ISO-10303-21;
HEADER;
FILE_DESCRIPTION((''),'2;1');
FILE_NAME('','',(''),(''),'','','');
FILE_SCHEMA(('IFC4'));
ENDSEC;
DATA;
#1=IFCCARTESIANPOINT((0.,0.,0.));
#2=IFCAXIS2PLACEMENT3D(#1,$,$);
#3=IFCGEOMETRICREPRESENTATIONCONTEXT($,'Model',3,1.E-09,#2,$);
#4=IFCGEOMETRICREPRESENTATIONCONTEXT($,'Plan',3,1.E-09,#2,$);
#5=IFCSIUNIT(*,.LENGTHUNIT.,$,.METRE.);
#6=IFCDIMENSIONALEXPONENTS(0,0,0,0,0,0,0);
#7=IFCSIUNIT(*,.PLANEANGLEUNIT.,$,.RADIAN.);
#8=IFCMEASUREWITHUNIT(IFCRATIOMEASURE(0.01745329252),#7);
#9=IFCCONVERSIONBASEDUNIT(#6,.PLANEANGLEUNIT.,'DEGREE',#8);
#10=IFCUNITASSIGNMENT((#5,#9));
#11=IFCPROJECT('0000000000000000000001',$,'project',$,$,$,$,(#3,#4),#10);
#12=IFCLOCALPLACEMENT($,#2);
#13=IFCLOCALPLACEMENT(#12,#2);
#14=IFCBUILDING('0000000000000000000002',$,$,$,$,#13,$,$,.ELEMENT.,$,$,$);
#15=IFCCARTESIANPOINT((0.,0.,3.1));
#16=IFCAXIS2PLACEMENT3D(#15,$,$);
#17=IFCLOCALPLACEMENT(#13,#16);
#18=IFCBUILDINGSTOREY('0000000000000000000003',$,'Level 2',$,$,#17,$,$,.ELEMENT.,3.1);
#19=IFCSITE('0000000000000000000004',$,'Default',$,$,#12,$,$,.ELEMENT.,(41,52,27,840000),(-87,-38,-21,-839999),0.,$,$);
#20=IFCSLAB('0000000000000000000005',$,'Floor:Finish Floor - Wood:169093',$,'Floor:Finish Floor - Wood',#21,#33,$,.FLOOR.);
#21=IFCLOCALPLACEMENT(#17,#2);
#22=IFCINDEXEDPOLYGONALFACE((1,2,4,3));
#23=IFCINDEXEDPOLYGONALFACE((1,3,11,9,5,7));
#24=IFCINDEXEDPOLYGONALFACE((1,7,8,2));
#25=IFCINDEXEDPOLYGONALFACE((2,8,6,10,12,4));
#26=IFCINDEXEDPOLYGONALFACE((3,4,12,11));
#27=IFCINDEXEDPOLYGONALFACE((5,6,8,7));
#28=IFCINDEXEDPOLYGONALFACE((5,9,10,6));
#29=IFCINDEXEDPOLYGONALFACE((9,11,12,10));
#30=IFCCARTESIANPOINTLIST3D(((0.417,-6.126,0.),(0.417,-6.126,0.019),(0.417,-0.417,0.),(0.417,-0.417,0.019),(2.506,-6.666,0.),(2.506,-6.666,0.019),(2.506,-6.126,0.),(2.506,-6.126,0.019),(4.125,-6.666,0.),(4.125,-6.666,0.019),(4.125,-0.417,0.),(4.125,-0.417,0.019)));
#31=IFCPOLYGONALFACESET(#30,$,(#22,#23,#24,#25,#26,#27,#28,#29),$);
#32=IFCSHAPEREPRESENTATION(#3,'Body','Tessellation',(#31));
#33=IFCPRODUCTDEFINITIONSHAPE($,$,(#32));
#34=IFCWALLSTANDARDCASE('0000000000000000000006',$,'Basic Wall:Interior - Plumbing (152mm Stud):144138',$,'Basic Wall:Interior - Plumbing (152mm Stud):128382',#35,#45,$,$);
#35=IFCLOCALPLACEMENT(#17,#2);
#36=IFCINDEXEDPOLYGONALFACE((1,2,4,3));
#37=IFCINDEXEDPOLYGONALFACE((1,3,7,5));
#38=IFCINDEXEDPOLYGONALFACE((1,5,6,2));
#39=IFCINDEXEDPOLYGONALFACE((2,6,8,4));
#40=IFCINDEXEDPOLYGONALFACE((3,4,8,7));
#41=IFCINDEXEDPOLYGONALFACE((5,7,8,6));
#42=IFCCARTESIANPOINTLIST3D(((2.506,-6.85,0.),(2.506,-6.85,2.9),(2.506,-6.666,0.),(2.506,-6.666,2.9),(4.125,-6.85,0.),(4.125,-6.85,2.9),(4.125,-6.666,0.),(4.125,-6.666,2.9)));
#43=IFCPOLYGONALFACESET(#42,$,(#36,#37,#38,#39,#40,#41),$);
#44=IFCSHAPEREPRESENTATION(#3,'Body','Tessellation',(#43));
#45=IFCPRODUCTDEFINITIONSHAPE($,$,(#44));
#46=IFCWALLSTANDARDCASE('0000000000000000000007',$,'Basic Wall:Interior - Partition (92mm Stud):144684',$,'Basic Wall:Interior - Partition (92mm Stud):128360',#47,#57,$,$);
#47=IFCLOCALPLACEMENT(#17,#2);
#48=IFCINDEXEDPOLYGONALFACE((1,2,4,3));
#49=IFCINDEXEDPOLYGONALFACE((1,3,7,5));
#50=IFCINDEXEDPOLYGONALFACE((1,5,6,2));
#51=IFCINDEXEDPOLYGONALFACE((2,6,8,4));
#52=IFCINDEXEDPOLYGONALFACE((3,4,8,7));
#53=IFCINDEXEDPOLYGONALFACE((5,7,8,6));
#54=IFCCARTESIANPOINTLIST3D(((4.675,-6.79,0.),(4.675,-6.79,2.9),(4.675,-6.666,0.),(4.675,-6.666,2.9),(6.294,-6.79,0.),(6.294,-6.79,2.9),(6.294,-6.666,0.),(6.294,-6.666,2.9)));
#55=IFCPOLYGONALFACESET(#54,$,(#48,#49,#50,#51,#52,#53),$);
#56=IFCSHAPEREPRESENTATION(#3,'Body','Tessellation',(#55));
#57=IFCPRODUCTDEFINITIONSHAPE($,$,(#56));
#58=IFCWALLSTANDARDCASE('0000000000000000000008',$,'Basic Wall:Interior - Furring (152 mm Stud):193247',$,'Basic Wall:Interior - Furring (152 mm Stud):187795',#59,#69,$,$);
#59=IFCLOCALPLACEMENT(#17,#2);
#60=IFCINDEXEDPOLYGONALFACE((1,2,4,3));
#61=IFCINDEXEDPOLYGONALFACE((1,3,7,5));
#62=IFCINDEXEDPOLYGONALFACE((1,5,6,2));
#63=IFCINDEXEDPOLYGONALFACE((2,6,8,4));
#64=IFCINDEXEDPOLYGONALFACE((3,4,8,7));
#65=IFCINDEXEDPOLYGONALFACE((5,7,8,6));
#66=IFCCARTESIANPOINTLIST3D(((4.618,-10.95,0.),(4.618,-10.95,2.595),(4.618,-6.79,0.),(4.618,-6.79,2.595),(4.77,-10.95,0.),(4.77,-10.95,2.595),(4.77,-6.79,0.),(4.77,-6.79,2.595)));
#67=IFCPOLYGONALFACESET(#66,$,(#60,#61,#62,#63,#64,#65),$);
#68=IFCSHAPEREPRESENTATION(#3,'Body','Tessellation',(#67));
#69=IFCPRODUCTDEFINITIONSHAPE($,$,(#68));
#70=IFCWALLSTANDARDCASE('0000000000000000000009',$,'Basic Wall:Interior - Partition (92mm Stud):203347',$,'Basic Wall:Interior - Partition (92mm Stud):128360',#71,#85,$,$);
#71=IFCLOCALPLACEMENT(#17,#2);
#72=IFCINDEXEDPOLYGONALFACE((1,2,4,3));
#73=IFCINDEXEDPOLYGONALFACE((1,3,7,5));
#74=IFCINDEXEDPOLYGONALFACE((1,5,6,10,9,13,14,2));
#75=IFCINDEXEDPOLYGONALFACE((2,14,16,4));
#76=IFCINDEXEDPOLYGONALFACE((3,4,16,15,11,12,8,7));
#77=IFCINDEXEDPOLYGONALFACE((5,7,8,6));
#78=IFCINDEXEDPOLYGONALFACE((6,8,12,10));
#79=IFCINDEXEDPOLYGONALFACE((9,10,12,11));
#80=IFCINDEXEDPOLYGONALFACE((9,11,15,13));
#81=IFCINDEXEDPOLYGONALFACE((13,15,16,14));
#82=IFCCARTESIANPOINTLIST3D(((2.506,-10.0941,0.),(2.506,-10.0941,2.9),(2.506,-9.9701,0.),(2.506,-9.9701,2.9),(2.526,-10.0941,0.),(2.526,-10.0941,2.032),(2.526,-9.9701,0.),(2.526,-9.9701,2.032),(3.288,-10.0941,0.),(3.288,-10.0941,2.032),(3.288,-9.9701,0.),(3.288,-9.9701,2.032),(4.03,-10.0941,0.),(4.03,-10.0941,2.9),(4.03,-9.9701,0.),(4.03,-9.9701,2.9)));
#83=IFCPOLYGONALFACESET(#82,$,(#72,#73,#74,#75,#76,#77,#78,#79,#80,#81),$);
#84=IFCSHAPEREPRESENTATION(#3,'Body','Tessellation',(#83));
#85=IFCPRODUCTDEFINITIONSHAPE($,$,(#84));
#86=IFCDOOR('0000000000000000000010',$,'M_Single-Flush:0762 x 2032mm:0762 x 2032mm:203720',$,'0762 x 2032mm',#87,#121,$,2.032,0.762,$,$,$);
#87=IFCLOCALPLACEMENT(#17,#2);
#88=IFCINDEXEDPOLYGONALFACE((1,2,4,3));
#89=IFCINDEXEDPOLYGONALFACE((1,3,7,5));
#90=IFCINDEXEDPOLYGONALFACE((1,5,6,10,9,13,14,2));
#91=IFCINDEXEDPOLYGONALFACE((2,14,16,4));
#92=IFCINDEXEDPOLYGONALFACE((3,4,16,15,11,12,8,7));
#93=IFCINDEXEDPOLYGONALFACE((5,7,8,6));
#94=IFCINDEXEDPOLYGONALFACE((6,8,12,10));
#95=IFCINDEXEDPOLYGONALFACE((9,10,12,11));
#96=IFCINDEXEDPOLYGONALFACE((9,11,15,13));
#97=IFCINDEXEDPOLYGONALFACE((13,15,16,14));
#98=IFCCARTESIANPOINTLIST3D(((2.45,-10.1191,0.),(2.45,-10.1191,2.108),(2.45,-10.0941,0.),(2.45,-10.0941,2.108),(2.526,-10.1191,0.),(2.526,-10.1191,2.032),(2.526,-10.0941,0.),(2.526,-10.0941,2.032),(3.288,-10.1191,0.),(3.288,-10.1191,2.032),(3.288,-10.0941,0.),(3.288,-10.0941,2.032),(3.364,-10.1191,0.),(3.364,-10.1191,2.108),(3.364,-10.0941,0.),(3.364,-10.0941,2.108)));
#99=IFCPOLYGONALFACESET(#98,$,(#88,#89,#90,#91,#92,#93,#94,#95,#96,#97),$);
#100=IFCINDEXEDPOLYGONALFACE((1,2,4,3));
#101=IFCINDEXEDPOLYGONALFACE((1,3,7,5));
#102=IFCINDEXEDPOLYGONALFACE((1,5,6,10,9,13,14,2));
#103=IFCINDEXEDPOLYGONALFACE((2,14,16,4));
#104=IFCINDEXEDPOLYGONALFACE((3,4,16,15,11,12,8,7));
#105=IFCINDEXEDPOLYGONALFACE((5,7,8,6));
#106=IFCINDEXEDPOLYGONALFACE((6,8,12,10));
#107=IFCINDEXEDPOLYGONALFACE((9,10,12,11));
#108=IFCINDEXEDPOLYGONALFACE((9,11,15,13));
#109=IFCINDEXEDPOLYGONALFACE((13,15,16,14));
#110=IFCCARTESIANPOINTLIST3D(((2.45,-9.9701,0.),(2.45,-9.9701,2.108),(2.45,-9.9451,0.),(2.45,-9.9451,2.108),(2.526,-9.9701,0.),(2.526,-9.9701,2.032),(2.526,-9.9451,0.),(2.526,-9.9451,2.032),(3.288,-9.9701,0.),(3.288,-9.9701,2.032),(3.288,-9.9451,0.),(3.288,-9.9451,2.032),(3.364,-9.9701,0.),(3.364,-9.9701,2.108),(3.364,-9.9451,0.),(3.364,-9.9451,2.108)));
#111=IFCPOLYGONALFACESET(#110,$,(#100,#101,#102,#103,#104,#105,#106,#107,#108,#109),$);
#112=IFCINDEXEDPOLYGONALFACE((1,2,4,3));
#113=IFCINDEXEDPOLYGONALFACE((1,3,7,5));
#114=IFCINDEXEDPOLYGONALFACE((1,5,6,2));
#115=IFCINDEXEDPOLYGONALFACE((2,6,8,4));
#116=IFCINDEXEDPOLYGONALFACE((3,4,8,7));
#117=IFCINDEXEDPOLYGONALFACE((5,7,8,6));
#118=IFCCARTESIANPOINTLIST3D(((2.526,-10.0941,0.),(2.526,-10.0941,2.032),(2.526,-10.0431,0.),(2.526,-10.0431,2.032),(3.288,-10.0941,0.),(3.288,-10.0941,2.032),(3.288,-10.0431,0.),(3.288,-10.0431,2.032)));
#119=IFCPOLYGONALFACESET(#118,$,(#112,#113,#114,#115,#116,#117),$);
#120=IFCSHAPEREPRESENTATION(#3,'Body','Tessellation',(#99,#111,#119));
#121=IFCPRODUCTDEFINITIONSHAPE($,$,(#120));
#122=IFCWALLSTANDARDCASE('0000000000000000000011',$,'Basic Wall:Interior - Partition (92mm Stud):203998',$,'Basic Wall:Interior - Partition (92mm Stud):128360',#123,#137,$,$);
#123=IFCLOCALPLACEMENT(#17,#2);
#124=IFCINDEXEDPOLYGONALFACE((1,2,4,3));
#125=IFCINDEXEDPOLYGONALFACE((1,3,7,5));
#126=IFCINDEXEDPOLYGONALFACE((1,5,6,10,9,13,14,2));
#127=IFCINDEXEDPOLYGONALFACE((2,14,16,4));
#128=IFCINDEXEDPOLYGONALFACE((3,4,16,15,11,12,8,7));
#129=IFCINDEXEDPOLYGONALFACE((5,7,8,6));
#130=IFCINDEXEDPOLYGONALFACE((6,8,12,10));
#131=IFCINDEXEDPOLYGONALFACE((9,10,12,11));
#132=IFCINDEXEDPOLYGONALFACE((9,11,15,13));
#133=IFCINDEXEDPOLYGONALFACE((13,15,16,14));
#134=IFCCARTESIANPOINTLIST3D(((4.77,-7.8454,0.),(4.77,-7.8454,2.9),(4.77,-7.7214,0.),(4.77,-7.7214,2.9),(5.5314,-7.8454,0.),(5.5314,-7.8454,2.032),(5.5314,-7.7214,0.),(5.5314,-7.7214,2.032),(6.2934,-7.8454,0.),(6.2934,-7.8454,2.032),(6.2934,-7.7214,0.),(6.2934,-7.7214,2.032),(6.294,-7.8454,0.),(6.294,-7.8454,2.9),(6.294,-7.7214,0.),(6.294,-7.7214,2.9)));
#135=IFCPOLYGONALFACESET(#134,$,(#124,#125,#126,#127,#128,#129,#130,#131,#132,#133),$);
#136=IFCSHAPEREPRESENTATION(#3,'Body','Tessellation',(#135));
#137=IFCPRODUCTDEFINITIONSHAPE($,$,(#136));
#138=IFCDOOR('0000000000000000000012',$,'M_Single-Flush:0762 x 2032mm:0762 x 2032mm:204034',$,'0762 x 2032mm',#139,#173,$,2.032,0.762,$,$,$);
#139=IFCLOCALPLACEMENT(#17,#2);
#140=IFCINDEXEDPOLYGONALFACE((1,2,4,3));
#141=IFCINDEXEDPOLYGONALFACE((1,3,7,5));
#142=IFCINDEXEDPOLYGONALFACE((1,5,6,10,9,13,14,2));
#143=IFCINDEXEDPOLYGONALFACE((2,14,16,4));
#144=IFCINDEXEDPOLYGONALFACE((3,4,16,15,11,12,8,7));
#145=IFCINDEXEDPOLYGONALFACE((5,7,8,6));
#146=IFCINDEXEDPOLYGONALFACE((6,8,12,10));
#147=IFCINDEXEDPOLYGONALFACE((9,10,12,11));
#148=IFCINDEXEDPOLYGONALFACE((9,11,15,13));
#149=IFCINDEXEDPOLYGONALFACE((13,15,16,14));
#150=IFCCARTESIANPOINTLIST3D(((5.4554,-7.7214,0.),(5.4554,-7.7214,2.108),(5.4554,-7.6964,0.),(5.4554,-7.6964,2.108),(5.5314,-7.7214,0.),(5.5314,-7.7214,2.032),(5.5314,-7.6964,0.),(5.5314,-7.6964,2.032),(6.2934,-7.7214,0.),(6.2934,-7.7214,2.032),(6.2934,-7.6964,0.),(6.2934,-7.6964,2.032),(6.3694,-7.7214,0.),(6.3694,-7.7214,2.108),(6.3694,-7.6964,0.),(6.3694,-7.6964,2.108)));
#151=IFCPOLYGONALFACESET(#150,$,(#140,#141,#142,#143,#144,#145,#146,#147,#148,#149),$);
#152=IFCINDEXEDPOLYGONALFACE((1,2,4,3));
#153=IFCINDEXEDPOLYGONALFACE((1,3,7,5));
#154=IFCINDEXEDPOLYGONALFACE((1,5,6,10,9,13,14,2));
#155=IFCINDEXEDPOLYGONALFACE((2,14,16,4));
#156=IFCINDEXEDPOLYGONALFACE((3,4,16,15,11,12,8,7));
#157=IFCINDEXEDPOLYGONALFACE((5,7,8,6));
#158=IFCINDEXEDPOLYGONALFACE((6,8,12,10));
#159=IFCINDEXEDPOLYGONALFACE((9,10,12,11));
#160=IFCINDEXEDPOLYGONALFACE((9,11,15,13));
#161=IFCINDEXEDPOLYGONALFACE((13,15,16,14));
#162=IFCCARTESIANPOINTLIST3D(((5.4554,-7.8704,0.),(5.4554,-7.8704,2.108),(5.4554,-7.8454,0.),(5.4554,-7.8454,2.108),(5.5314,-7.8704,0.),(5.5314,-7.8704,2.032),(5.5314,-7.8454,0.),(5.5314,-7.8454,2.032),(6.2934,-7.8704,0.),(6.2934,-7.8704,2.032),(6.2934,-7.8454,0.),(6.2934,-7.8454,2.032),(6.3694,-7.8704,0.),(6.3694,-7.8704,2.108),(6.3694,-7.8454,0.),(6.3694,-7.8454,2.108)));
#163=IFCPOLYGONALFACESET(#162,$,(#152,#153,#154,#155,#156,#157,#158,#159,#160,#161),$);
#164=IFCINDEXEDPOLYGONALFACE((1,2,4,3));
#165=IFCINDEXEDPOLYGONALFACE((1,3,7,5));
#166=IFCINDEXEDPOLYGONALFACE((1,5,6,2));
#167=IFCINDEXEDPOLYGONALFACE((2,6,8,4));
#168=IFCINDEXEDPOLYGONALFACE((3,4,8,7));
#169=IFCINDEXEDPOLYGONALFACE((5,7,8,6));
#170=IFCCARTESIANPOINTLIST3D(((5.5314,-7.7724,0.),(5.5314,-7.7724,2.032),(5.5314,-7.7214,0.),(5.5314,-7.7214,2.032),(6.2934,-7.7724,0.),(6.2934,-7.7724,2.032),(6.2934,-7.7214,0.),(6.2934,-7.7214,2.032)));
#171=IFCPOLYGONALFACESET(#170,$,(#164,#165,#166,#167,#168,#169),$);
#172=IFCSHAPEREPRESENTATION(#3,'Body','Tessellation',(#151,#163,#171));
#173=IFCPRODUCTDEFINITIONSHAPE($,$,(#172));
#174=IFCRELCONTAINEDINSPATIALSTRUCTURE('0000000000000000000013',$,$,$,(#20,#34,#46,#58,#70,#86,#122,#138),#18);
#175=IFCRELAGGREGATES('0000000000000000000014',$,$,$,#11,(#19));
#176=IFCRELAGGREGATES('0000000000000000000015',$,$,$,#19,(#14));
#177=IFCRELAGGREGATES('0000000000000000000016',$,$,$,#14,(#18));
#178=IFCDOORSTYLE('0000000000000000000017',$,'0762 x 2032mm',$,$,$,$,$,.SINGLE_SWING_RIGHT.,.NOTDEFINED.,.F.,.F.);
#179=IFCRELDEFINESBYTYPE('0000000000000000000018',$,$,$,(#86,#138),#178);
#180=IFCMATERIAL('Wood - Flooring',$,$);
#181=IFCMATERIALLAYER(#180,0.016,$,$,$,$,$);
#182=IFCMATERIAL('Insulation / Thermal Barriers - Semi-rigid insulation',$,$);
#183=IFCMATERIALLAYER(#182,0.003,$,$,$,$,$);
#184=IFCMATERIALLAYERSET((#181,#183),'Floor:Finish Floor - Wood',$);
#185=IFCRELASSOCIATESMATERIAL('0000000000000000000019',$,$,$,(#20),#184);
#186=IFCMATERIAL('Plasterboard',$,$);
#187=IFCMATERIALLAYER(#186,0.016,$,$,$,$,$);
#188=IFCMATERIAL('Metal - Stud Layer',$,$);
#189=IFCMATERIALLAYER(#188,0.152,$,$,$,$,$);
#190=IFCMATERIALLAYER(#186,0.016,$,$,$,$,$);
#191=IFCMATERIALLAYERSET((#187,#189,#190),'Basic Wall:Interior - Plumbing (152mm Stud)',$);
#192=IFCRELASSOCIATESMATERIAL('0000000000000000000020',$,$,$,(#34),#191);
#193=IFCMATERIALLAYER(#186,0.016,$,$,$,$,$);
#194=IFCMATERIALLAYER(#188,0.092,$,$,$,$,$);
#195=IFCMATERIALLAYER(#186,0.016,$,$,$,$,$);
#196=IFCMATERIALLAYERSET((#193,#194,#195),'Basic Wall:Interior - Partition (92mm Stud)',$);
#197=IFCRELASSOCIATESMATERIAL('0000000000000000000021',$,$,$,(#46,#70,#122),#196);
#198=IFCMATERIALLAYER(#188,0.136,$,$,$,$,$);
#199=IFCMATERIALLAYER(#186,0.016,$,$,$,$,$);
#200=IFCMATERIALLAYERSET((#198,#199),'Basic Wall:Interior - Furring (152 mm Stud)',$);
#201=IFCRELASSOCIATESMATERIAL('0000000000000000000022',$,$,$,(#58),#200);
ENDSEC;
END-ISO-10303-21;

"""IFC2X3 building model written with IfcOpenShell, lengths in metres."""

from ifc_helpers import new_model, entity, si_unit, converted_unit, frame, frame_2d, origin, origin_2d_with_axis, place, context, project, spatial, polyline, rectangle, outline, extrude, source, transform, mapped, material, layer, layer_set, layer_usage, type_object, type_shapes, element, fill, save


model = new_model("IFC2X3")

# Units and contexts
model_context = context("Model", 3, precision=1e-09, world=origin())
plan_context = context("Plan", 3, precision=1e-09, world=origin())
ifc_project = project(units=[si_unit("LENGTHUNIT", "METRE"), converted_unit("PLANEANGLEUNIT", "DEGREE", entity("IfcRatioMeasure", 0.01745329252), si_unit("PLANEANGLEUNIT", "RADIAN"), dimensions=[0, 0, 0, 0, 0, 0, 0])], contexts=[model_context, plan_context])

# Site, building, storey
site_placement = place(None, origin())
site = spatial("IfcSite", under=ifc_project, at=site_placement, Name="Default", CompositionType="ELEMENT", RefLatitude=(41, 52, 27, 840000), RefLongitude=(-87, -38, -21, -839999), RefElevation=0.0)
building_placement = place(site_placement, origin())
building = spatial("IfcBuilding", under=site, at=building_placement, CompositionType="ELEMENT")
storey_placement = place(building_placement, frame((0.0, 0.0, 3.1)))
storey = spatial("IfcBuildingStorey", under=building, at=storey_placement, Name="Level 2", CompositionType="ELEMENT", Elevation=3.1)

# Slab
ifc_material_1 = material(Name="Wood - Flooring")
ifc_layer_1 = layer(ifc_material_1, 0.016)
ifc_material_2 = material(Name="Insulation / Thermal Barriers - Semi-rigid insulation")
ifc_layer_2 = layer(ifc_material_2, 0.003)
ifc_layer_set_1 = layer_set([ifc_layer_1, ifc_layer_2], Name="Floor:Finish Floor - Wood")
ifc_layer_usage_1 = layer_usage(ifc_layer_set_1, "AXIS3", "POSITIVE", 0.0)
slab_placement = place(storey_placement, frame((0.417, -6.666, 0.0)))
element("IfcSlab", 1, at=slab_placement, inside=storey, material=ifc_layer_usage_1, Name="Floor:Finish Floor - Wood:169093", ObjectType="Floor:Finish Floor - Wood", PredefinedType="FLOOR", context=model_context, shape_type="SweptSolid", body=[
    extrude(outline(polyline([(1.854, 3.1245), (-1.854, 3.1245), (-1.854, -3.1245), (-0.235, -3.1245), (-0.235, -2.5845), (1.854, -2.5845), (1.854, 3.1245)])), frame((1.854, 3.1245, 0.019), z_axis=(0.0, 0.0, -1.0), x_axis=(-1.0, 0.0, 0.0)), (0.0, 0.0, 1.0), 0.019),
])

# Walls
ifc_material_3 = material(Name="Plasterboard")
ifc_layer_3 = layer(ifc_material_3, 0.016)
ifc_material_4 = material(Name="Metal - Stud Layer")
ifc_layer_4 = layer(ifc_material_4, 0.152)
ifc_layer_5 = layer(ifc_material_3, 0.016)
ifc_layer_set_2 = layer_set([ifc_layer_3, ifc_layer_4, ifc_layer_5], Name="Basic Wall:Interior - Plumbing (152mm Stud)")
ifc_layer_usage_2 = layer_usage(ifc_layer_set_2, "AXIS2", "NEGATIVE", 0.092)
wall_1_placement = place(storey_placement, frame((2.506, -6.758, 0.0)))
element("IfcWallStandardCase", 2, at=wall_1_placement, inside=storey, material=ifc_layer_usage_2, Name="Basic Wall:Interior - Plumbing (152mm Stud):144138", ObjectType="Basic Wall:Interior - Plumbing (152mm Stud):128382", context=model_context, shape_type="SweptSolid", body=[
    extrude(rectangle(XDim=1.619, YDim=0.184, at=frame_2d((0.8095, 0.0), x_axis=(-1.0, 0.0))), origin(), (0.0, 0.0, 1.0), 2.9),
])
ifc_layer_6 = layer(ifc_material_3, 0.016)
ifc_layer_7 = layer(ifc_material_4, 0.092)
ifc_layer_8 = layer(ifc_material_3, 0.016)
ifc_layer_set_3 = layer_set([ifc_layer_6, ifc_layer_7, ifc_layer_8], Name="Basic Wall:Interior - Partition (92mm Stud)")
ifc_layer_usage_3 = layer_usage(ifc_layer_set_3, "AXIS2", "NEGATIVE", 0.062)
wall_2_placement = place(storey_placement, frame((4.675, -6.728, 0.0)))
element("IfcWallStandardCase", 3, at=wall_2_placement, inside=storey, material=ifc_layer_usage_3, Name="Basic Wall:Interior - Partition (92mm Stud):144684", ObjectType="Basic Wall:Interior - Partition (92mm Stud):128360", context=model_context, shape_type="SweptSolid", body=[
    extrude(rectangle(XDim=1.619, YDim=0.124, at=frame_2d((0.8095, 0.0), x_axis=(-1.0, 0.0))), origin(), (0.0, 0.0, 1.0), 2.9),
])
ifc_layer_9 = layer(ifc_material_4, 0.136)
ifc_layer_10 = layer(ifc_material_3, 0.016)
ifc_layer_set_4 = layer_set([ifc_layer_9, ifc_layer_10], Name="Basic Wall:Interior - Furring (152 mm Stud)")
ifc_layer_usage_4 = layer_usage(ifc_layer_set_4, "AXIS2", "POSITIVE", -0.076)
wall_3_placement = place(storey_placement, frame((4.694, -6.79, 0.0), z_axis=(0.0, 0.0, 1.0), x_axis=(0.0, -1.0, 0.0)))
element("IfcWallStandardCase", 4, at=wall_3_placement, inside=storey, material=ifc_layer_usage_4, Name="Basic Wall:Interior - Furring (152 mm Stud):193247", ObjectType="Basic Wall:Interior - Furring (152 mm Stud):187795", context=model_context, shape_type="SweptSolid", body=[
    extrude(rectangle(XDim=4.16, YDim=0.152, at=frame_2d((2.08, 0.0), x_axis=(-1.0, 0.0))), origin(), (0.0, 0.0, 1.0), 2.595),
])

# Walls, openings, doors
ifc_layer_usage_5 = layer_usage(ifc_layer_set_3, "AXIS2", "NEGATIVE", 0.062)
wall_4_placement = place(storey_placement, frame((4.03, -10.0321, 0.0), z_axis=(0.0, 0.0, 1.0), x_axis=(-1.0, 0.0, 0.0)))
wall_4 = element("IfcWallStandardCase", 5, at=wall_4_placement, inside=storey, material=ifc_layer_usage_5, Name="Basic Wall:Interior - Partition (92mm Stud):203347", ObjectType="Basic Wall:Interior - Partition (92mm Stud):128360", context=model_context, shape_type="SweptSolid", body=[
    extrude(rectangle(XDim=1.524, YDim=0.124, at=frame_2d((0.762, 0.0), x_axis=(-1.0, 0.0))), origin(), (0.0, 0.0, 1.0), 2.9),
])
opening_1_placement = place(wall_4_placement, frame((0.742, -0.062, 0.0)))
opening_1 = element("IfcOpeningElement", 6, at=opening_1_placement, cuts=wall_4, ObjectType="Opening", context=model_context, shape_type="SweptSolid", body=[
    extrude(rectangle(XDim=0.762, YDim=2.032, at=frame_2d((1.016, 0.381), x_axis=(0.0, 1.0))), frame((0.0, 0.0, 0.0), z_axis=(0.0, 1.0, 0.0), x_axis=(0.0, 0.0, 1.0)), (0.0, 0.0, 1.0), 0.124),
])
door_style = type_object("IfcDoorStyle", Name="0762 x 2032mm", ConstructionType="NOTDEFINED", OperationType="SINGLE_SWING_RIGHT", ParameterTakesPrecedence=False, Sizeable=False)
shared_shape = source(origin(), model_context, "Body", "SweptSolid", [
    extrude(outline(polyline([(-0.457, -1.073), (0.457, -1.073), (0.457, 1.035), (0.381, 1.035), (0.381, -0.997), (-0.381, -0.997), (-0.381, 1.035), (-0.457, 1.035), (-0.457, -1.073)])), frame((0.381, 0.124, 1.035), z_axis=(0.0, 1.0, 0.0), x_axis=(1.0, 0.0, 0.0)), (0.0, 0.0, 1.0), 0.025),
    extrude(outline(polyline([(-1.073, -0.457), (1.035, -0.457), (1.035, -0.381), (-0.997, -0.381), (-0.997, 0.381), (1.035, 0.381), (1.035, 0.457), (-1.073, 0.457), (-1.073, -0.457)])), frame((0.381, -0.025, 1.035), z_axis=(0.0, 1.0, 0.0), x_axis=(0.0, 0.0, -1.0)), (0.0, 0.0, 1.0), 0.025),
    extrude(rectangle(XDim=0.051, YDim=0.762, at=origin_2d_with_axis()), frame((0.381, 0.0985, 0.0), z_axis=(0.0, 0.0, 1.0), x_axis=(0.0, 1.0, 0.0)), (0.0, 0.0, 1.0), 2.032),
])
type_shapes(door_style, [shared_shape])
door_1_placement = place(opening_1_placement, origin())
door_1 = element("IfcDoor", 7, at=door_1_placement, inside=storey, type_object=door_style, Name="M_Single-Flush:0762 x 2032mm:0762 x 2032mm:203720", ObjectType="0762 x 2032mm", OverallHeight=2.032, OverallWidth=0.762, context=model_context, shape_type="MappedRepresentation", body=[
    mapped(shared_shape, transform((0.0, 0.0, 0.0), scale=1.0)),
])
fill(opening_1, door_1)
ifc_layer_usage_6 = layer_usage(ifc_layer_set_3, "AXIS2", "POSITIVE", -0.062)
wall_5_placement = place(storey_placement, frame((4.77, -7.7834, 0.0)))
wall_5 = element("IfcWallStandardCase", 8, at=wall_5_placement, inside=storey, material=ifc_layer_usage_6, Name="Basic Wall:Interior - Partition (92mm Stud):203998", ObjectType="Basic Wall:Interior - Partition (92mm Stud):128360", context=model_context, shape_type="SweptSolid", body=[
    extrude(rectangle(XDim=1.524, YDim=0.124, at=frame_2d((0.762, 0.0), x_axis=(-1.0, 0.0))), origin(), (0.0, 0.0, 1.0), 2.9),
])
opening_2_placement = place(wall_5_placement, frame((0.7614, -0.062, 0.0)))
opening_2 = element("IfcOpeningElement", 9, at=opening_2_placement, cuts=wall_5, ObjectType="Opening", context=model_context, shape_type="SweptSolid", body=[
    extrude(rectangle(XDim=0.762, YDim=2.032, at=frame_2d((1.016, 0.381), x_axis=(0.0, 1.0))), frame((0.0, 0.0, 0.0), z_axis=(0.0, 1.0, 0.0), x_axis=(0.0, 0.0, 1.0)), (0.0, 0.0, 1.0), 0.124),
])
door_2_placement = place(opening_2_placement, origin())
door_2 = element("IfcDoor", 10, at=door_2_placement, inside=storey, type_object=door_style, Name="M_Single-Flush:0762 x 2032mm:0762 x 2032mm:204034", ObjectType="0762 x 2032mm", OverallHeight=2.032, OverallWidth=0.762, context=model_context, shape_type="MappedRepresentation", body=[
    mapped(shared_shape, transform((0.0, 0.0, 0.0), scale=1.0)),
])
fill(opening_2, door_2)

save(model, "model.ifc")
